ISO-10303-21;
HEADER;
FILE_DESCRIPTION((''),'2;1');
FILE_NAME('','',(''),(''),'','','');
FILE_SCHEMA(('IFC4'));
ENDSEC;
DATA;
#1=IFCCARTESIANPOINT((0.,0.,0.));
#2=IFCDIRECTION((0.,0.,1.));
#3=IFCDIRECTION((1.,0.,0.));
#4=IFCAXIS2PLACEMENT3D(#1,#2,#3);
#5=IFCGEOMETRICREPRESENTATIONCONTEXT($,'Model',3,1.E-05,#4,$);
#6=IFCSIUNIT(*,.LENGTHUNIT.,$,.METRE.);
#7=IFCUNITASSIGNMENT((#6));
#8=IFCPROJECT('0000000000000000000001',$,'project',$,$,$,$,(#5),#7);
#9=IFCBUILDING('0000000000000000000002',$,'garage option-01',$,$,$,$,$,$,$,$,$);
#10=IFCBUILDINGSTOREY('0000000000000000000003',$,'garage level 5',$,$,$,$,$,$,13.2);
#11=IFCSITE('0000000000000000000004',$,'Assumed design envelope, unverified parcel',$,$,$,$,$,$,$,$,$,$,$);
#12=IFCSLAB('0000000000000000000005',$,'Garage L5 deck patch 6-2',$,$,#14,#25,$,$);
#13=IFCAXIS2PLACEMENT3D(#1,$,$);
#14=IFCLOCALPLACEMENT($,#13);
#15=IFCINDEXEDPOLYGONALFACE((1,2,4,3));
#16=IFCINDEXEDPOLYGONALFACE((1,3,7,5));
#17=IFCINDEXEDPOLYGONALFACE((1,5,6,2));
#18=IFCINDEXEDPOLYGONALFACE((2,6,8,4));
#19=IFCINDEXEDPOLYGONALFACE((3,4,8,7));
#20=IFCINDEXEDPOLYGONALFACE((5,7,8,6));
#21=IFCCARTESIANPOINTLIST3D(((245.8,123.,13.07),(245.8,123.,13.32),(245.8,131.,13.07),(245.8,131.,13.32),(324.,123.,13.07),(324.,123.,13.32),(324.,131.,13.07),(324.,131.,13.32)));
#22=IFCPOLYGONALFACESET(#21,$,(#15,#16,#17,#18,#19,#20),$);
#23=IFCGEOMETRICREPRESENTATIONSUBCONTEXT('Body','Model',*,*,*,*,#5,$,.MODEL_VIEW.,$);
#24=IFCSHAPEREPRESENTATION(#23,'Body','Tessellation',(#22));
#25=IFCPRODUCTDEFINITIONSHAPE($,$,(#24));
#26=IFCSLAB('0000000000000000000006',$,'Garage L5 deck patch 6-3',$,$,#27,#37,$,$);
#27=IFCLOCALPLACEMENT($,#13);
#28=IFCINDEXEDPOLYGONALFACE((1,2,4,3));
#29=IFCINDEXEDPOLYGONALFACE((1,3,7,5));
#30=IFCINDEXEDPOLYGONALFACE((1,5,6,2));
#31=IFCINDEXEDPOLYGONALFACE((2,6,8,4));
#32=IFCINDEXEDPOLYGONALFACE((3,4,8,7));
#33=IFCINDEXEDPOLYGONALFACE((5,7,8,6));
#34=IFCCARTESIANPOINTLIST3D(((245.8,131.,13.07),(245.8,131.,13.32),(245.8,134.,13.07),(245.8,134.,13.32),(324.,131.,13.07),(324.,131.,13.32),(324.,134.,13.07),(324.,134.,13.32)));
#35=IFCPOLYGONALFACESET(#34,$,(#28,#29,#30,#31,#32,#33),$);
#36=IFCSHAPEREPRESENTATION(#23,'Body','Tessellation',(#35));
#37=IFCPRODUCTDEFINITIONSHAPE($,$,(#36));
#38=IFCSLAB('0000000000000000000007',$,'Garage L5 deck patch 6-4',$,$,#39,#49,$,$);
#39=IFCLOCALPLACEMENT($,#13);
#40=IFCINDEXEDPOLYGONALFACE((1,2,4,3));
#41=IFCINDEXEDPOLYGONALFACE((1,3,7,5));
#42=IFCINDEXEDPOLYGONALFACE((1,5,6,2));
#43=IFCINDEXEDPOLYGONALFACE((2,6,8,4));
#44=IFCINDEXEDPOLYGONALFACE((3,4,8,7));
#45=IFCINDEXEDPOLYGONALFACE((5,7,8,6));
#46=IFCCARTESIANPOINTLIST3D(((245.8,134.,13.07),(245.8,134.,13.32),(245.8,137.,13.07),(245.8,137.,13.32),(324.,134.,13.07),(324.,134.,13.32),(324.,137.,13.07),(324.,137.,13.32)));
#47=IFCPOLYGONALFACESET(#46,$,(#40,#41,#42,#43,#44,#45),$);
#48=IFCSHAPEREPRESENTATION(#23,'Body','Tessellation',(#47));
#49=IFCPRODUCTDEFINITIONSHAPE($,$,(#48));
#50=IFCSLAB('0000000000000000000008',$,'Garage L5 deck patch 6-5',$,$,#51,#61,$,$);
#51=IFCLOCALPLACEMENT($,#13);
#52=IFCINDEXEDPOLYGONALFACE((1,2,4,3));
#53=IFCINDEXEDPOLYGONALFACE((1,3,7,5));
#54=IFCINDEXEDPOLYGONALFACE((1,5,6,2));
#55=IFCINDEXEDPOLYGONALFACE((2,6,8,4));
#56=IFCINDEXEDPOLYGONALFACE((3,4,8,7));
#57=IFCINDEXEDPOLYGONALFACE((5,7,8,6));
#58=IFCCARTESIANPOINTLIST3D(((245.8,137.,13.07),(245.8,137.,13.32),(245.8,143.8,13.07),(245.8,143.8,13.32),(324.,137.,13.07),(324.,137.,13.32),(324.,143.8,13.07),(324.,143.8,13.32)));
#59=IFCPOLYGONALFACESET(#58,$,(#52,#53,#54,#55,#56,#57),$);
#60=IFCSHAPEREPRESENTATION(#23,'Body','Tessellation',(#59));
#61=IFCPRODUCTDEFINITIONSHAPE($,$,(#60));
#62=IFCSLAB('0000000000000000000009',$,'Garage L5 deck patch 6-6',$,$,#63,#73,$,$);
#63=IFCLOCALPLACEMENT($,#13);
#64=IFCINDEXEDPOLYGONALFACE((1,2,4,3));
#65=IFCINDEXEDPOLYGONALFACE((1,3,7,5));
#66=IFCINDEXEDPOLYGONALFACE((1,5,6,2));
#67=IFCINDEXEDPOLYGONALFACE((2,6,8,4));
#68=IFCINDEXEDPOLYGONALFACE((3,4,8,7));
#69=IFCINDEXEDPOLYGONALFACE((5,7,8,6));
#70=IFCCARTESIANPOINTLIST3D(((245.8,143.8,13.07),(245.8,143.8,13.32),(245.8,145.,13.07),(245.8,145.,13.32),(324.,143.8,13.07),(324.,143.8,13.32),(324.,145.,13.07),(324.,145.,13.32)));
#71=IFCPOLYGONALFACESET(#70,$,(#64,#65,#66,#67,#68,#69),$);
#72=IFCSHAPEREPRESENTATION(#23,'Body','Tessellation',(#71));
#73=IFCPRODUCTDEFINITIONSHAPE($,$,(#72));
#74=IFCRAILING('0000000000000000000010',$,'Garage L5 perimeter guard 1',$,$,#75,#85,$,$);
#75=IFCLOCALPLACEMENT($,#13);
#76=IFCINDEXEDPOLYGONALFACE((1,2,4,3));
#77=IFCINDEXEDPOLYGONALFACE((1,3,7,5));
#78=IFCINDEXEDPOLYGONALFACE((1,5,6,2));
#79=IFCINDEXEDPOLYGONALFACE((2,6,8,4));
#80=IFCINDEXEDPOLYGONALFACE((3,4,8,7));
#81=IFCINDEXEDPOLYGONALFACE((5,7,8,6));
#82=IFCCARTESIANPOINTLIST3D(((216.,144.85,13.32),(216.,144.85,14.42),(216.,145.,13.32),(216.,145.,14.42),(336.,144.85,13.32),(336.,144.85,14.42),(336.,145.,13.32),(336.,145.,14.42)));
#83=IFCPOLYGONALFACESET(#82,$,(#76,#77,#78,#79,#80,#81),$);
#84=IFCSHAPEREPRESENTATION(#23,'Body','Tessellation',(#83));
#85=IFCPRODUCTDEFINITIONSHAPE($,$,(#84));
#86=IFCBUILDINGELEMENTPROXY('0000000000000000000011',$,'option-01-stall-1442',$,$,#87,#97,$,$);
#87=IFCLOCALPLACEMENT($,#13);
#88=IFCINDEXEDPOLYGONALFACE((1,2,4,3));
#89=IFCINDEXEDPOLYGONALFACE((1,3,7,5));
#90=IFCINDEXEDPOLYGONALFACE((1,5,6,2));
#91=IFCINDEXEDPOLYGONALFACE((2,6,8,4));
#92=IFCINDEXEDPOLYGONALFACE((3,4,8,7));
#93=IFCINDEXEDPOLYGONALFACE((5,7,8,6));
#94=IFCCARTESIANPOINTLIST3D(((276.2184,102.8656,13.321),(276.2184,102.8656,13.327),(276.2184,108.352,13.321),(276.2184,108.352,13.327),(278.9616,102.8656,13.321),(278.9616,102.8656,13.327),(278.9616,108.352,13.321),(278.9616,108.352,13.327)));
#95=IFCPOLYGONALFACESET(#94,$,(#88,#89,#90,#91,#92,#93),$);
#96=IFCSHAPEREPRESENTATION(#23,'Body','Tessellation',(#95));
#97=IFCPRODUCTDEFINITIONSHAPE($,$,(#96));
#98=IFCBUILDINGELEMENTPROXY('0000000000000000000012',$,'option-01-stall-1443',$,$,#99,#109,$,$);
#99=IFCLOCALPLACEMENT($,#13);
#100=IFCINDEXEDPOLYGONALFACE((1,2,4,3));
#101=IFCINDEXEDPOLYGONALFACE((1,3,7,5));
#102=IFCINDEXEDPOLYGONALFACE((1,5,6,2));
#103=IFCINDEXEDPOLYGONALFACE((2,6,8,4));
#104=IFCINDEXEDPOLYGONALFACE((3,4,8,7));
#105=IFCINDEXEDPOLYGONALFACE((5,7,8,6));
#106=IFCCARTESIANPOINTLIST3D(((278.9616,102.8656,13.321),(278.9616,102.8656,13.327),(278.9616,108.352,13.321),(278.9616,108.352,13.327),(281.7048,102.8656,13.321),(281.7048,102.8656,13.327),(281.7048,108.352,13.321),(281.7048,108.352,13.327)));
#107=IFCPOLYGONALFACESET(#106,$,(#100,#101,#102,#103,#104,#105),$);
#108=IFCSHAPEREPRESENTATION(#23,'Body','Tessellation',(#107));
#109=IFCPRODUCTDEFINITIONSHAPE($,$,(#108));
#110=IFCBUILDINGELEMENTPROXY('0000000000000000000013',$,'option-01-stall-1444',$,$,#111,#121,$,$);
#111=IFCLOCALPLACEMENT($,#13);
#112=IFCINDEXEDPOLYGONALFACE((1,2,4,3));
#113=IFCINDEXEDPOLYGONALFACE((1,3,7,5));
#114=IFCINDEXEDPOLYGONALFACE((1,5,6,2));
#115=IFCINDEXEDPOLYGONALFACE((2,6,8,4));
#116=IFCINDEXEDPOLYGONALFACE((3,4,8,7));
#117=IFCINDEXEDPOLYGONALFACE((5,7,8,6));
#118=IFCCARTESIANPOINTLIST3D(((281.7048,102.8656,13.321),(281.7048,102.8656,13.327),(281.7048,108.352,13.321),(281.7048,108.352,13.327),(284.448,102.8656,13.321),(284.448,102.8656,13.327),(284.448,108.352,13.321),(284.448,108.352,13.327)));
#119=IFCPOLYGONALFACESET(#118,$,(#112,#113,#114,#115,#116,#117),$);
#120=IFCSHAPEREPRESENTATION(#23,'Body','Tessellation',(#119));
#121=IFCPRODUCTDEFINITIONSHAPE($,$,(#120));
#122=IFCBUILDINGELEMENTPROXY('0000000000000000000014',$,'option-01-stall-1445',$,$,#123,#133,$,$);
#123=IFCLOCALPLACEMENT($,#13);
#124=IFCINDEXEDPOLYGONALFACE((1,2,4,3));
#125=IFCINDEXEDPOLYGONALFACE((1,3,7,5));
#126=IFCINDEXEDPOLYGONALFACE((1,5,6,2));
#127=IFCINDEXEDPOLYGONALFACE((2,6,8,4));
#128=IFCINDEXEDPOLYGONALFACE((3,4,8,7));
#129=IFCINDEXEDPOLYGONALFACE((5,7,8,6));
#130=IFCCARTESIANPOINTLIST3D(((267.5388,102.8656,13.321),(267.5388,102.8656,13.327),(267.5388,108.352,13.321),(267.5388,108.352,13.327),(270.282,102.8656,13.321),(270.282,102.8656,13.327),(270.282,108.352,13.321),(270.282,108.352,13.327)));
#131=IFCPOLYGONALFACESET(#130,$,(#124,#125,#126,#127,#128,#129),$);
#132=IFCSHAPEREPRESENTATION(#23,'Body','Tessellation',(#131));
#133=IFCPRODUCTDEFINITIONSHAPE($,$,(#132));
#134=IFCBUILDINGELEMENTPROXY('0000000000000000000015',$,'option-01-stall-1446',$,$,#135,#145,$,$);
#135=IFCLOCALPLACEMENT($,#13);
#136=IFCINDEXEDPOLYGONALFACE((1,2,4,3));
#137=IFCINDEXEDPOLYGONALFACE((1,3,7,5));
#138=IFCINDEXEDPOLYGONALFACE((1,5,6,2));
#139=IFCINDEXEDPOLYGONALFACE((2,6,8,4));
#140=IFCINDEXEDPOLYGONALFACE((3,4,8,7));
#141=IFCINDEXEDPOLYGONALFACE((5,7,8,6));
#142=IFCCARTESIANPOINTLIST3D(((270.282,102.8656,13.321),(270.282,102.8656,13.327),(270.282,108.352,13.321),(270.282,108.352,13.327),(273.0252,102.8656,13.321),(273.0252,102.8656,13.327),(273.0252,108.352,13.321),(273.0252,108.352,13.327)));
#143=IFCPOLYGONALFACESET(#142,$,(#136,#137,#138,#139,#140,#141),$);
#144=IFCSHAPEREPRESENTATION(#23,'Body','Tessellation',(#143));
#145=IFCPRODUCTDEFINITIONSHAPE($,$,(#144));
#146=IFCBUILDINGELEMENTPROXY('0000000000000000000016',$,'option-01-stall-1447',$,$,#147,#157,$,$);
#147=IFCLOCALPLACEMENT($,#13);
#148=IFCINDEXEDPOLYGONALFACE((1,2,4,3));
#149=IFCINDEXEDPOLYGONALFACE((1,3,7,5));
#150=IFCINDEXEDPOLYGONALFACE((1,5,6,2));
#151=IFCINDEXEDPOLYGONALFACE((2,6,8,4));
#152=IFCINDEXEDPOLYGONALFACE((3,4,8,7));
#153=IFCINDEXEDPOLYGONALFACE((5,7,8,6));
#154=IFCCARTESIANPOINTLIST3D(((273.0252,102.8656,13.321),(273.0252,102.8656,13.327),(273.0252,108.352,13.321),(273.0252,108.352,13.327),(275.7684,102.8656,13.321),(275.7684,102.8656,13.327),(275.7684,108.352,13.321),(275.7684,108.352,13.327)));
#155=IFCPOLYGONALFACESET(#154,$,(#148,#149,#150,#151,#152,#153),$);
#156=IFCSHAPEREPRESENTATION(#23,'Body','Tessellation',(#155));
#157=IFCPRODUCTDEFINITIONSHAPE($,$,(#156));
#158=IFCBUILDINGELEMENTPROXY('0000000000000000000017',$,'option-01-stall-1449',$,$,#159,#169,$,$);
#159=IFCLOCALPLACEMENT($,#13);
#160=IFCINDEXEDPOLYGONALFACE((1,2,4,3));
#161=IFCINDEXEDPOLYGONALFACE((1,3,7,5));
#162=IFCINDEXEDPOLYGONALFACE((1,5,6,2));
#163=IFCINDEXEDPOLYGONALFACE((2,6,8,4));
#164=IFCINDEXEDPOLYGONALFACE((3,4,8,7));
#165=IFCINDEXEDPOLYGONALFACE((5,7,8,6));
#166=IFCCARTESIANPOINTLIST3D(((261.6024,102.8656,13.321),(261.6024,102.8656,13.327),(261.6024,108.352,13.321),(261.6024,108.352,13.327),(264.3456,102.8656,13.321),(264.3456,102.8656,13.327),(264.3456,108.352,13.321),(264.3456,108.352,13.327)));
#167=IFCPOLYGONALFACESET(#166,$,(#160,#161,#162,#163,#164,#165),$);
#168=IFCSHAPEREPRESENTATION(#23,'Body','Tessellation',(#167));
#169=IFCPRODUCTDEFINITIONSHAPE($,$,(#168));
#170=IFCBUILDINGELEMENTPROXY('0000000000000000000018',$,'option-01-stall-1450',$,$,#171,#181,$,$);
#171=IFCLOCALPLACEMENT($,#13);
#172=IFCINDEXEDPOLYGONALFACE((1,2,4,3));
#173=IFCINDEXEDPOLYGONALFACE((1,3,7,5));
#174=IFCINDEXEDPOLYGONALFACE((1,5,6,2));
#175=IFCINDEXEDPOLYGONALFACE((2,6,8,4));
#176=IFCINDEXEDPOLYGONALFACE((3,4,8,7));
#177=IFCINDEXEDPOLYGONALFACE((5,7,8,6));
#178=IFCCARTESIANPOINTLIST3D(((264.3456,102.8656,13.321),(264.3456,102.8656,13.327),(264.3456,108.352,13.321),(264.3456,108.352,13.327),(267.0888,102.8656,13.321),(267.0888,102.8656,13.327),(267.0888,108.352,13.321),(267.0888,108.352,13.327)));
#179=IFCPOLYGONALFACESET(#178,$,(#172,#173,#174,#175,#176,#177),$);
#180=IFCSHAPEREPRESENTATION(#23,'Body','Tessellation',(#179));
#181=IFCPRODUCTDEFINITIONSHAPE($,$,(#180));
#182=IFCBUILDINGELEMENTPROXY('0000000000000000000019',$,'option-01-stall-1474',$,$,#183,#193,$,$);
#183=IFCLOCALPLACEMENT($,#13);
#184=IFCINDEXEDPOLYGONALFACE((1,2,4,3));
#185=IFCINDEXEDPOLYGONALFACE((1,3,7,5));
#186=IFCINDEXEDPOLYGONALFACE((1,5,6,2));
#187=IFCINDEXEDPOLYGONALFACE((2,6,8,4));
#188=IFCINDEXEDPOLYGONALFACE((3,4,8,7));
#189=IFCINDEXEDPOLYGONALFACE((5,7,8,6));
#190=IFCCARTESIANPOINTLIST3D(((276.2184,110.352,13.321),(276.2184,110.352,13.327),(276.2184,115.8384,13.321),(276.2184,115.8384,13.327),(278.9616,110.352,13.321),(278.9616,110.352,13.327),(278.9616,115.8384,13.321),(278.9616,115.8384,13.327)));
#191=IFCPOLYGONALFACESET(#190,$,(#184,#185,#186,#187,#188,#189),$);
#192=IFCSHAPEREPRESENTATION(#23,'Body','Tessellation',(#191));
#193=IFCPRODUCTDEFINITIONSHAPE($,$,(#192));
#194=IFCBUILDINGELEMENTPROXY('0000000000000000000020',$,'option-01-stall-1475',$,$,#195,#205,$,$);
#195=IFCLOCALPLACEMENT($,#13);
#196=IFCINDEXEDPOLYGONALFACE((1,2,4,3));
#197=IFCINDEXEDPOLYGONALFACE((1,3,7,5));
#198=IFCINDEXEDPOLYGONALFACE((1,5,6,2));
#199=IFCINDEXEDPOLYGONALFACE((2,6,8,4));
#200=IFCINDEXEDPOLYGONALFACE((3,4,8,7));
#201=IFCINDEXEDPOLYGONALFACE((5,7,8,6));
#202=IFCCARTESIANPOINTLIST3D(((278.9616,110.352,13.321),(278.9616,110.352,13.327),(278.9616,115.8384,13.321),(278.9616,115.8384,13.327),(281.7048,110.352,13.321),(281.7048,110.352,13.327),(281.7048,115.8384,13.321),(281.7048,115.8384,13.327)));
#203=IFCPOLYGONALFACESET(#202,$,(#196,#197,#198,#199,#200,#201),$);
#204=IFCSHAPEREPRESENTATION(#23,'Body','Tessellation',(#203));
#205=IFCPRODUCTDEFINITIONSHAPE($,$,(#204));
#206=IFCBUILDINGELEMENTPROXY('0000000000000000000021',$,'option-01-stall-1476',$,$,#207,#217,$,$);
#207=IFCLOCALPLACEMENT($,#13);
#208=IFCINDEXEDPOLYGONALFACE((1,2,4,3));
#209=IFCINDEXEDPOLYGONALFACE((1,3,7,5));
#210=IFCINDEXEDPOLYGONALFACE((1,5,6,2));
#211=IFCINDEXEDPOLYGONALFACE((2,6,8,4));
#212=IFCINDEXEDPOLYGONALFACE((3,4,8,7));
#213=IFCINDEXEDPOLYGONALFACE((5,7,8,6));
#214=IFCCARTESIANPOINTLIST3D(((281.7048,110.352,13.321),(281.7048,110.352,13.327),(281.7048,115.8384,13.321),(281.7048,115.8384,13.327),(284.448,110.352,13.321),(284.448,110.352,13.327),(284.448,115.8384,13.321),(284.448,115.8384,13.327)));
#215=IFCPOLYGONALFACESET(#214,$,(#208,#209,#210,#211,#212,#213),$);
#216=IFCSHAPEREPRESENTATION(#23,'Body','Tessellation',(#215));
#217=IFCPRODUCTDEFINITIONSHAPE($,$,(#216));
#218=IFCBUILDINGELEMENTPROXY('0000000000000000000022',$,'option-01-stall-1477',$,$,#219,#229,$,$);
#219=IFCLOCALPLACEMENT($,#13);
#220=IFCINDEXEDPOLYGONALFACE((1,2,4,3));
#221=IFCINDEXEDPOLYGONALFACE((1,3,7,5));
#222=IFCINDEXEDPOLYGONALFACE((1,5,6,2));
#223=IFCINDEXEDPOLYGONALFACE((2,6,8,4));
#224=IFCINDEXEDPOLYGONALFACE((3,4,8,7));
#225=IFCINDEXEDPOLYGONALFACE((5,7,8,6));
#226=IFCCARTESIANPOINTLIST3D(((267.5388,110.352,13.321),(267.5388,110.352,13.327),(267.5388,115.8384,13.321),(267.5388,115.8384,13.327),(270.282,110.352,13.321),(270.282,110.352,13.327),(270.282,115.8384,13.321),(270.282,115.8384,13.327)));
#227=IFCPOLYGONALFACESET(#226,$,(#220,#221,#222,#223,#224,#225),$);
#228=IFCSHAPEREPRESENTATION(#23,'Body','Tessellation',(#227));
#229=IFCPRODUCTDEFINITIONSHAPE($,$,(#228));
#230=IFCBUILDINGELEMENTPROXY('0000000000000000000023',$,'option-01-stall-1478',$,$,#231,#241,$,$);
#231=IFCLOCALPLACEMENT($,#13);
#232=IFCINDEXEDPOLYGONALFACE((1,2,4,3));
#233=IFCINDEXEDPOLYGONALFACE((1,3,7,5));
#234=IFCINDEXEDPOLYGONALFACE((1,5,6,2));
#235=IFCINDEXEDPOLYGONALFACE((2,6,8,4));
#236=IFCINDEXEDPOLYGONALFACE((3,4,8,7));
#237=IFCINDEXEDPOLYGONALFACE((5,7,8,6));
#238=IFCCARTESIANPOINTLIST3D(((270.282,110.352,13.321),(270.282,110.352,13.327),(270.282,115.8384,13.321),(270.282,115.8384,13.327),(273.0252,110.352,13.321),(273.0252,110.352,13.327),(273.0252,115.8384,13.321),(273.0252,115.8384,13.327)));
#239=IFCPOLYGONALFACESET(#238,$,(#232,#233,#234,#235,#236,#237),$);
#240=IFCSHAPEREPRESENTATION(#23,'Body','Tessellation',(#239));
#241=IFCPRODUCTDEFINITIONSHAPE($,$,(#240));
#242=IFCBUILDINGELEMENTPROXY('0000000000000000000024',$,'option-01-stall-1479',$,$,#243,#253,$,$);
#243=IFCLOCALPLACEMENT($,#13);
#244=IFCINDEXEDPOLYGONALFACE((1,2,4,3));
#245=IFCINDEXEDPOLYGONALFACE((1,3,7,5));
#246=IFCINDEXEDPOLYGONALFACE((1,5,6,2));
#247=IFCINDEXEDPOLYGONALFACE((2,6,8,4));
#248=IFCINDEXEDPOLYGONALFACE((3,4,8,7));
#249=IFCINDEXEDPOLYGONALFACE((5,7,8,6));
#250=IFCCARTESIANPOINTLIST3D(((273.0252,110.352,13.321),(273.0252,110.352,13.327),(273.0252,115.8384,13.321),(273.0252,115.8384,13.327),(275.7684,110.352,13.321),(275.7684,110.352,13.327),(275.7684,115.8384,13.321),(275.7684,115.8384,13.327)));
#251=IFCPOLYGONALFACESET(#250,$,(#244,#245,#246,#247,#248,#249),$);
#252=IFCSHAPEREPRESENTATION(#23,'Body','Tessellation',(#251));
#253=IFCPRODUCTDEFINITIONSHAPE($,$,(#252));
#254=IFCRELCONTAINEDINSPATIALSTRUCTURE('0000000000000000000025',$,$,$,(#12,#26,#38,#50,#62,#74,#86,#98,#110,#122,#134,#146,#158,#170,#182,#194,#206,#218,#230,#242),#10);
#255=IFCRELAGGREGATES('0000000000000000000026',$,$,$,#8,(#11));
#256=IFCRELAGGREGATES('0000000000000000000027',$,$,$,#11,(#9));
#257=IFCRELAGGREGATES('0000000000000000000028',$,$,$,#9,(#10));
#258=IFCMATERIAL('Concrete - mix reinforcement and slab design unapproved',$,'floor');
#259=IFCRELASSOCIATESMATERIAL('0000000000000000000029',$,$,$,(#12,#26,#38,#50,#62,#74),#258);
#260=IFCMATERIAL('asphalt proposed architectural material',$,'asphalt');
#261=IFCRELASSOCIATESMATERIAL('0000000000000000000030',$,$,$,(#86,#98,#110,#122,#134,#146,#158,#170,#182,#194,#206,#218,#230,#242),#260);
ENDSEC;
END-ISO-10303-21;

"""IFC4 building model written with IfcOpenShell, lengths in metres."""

from ifc_helpers import new_model, si_unit, frame, origin_with_axes, place, context, subcontext, project, spatial, rectangle, extrude, material, element, save


model = new_model("IFC4")

# Units and contexts
model_context = context("Model", 3, precision=1e-05, world=origin_with_axes())
body_context = subcontext(model_context, "Body", "Model", "MODEL_VIEW")
ifc_project = project(units=[si_unit("LENGTHUNIT", "METRE")], contexts=[model_context])

# Site, building, storey
site = spatial("IfcSite", under=ifc_project, Name="Assumed design envelope, unverified parcel")
building = spatial("IfcBuilding", under=site, Name="garage option-01")
storey = spatial("IfcBuildingStorey", under=building, Name="garage level 5", Elevation=13.2)

# Slabs
ifc_material_1 = material(Name="Concrete - mix reinforcement and slab design unapproved", Category="floor")
slab_1_placement = place(None, frame((284.9, 127.0, 13.07), z_axis=(0.0, 0.0, 1.0), x_axis=(1.0, 0.0, 0.0)))
element("IfcSlab", 1, at=slab_1_placement, inside=storey, material=ifc_material_1, Name="Garage L5 deck patch 6-2", context=body_context, shape_type="SweptSolid", body=[
    extrude(rectangle(XDim=78.2, YDim=8.0), origin_with_axes(), (0.0, 0.0, 1.0), 0.25),
])
for number, where, z_axis, x_axis, name in (
    (2, (284.9, 132.5, 13.07), (0.0, 0.0, 1.0), (1.0, 0.0, 0.0), "Garage L5 deck patch 6-3"),
    (3, (284.9, 135.5, 13.07), (0.0, 0.0, 1.0), (1.0, 0.0, 0.0), "Garage L5 deck patch 6-4"),
):
    element("IfcSlab", number, at=place(None, frame(where, z_axis=z_axis, x_axis=x_axis)), inside=storey, material=ifc_material_1, Name=name, context=body_context, shape_type="SweptSolid", body=[
        extrude(rectangle(XDim=78.2, YDim=3.0), origin_with_axes(), (0.0, 0.0, 1.0), 0.25),
    ])
slab_2_placement = place(None, frame((284.9, 140.4, 13.07), z_axis=(0.0, 0.0, 1.0), x_axis=(1.0, 0.0, 0.0)))
element("IfcSlab", 4, at=slab_2_placement, inside=storey, material=ifc_material_1, Name="Garage L5 deck patch 6-5", context=body_context, shape_type="SweptSolid", body=[
    extrude(rectangle(XDim=78.2, YDim=6.8), origin_with_axes(), (0.0, 0.0, 1.0), 0.25),
])
slab_3_placement = place(None, frame((284.9, 144.4, 13.07), z_axis=(0.0, 0.0, 1.0), x_axis=(1.0, 0.0, 0.0)))
element("IfcSlab", 5, at=slab_3_placement, inside=storey, material=ifc_material_1, Name="Garage L5 deck patch 6-6", context=body_context, shape_type="SweptSolid", body=[
    extrude(rectangle(XDim=78.2, YDim=1.2), origin_with_axes(), (0.0, 0.0, 1.0), 0.25),
])

# Railing
railing_placement = place(None, frame((276.0, 144.925, 13.32), z_axis=(0.0, 0.0, 1.0), x_axis=(1.0, 0.0, 0.0)))
element("IfcRailing", 6, at=railing_placement, inside=storey, material=ifc_material_1, Name="Garage L5 perimeter guard 1", context=body_context, shape_type="SweptSolid", body=[
    extrude(rectangle(XDim=120.0, YDim=0.15), origin_with_axes(), (0.0, 0.0, 1.0), 1.1),
])

# Building element proxies
ifc_material_2 = material(Name="asphalt proposed architectural material", Category="asphalt")
for number, where, z_axis, x_axis, name in (
    (7, (277.59, 105.6088, 13.321), (0.0, 0.0, 1.0), (1.0, 0.0, 0.0), "option-01-stall-1442"),
    (8, (280.3332, 105.6088, 13.321), (0.0, 0.0, 1.0), (1.0, 0.0, 0.0), "option-01-stall-1443"),
    (9, (283.0764, 105.6088, 13.321), (0.0, 0.0, 1.0), (1.0, 0.0, 0.0), "option-01-stall-1444"),
    (10, (268.9104, 105.6088, 13.321), (0.0, 0.0, 1.0), (1.0, 0.0, 0.0), "option-01-stall-1445"),
    (11, (271.6536, 105.6088, 13.321), (0.0, 0.0, 1.0), (1.0, 0.0, 0.0), "option-01-stall-1446"),
    (12, (274.3968, 105.6088, 13.321), (0.0, 0.0, 1.0), (1.0, 0.0, 0.0), "option-01-stall-1447"),
    (13, (262.974, 105.6088, 13.321), (0.0, 0.0, 1.0), (1.0, 0.0, 0.0), "option-01-stall-1449"),
    (14, (265.7172, 105.6088, 13.321), (0.0, 0.0, 1.0), (1.0, 0.0, 0.0), "option-01-stall-1450"),
    (15, (277.59, 113.0952, 13.321), (0.0, 0.0, 1.0), (1.0, 0.0, 0.0), "option-01-stall-1474"),
    (16, (280.3332, 113.0952, 13.321), (0.0, 0.0, 1.0), (1.0, 0.0, 0.0), "option-01-stall-1475"),
    (17, (283.0764, 113.0952, 13.321), (0.0, 0.0, 1.0), (1.0, 0.0, 0.0), "option-01-stall-1476"),
    (18, (268.9104, 113.0952, 13.321), (0.0, 0.0, 1.0), (1.0, 0.0, 0.0), "option-01-stall-1477"),
    (19, (271.6536, 113.0952, 13.321), (0.0, 0.0, 1.0), (1.0, 0.0, 0.0), "option-01-stall-1478"),
    (20, (274.3968, 113.0952, 13.321), (0.0, 0.0, 1.0), (1.0, 0.0, 0.0), "option-01-stall-1479"),
):
    element("IfcBuildingElementProxy", number, at=place(None, frame(where, z_axis=z_axis, x_axis=x_axis)), inside=storey, material=ifc_material_2, Name=name, context=body_context, shape_type="SweptSolid", body=[
        extrude(rectangle(XDim=2.7432, YDim=5.4864), origin_with_axes(), (0.0, 0.0, 1.0), 0.006),
    ])

save(model, "model.ifc")
